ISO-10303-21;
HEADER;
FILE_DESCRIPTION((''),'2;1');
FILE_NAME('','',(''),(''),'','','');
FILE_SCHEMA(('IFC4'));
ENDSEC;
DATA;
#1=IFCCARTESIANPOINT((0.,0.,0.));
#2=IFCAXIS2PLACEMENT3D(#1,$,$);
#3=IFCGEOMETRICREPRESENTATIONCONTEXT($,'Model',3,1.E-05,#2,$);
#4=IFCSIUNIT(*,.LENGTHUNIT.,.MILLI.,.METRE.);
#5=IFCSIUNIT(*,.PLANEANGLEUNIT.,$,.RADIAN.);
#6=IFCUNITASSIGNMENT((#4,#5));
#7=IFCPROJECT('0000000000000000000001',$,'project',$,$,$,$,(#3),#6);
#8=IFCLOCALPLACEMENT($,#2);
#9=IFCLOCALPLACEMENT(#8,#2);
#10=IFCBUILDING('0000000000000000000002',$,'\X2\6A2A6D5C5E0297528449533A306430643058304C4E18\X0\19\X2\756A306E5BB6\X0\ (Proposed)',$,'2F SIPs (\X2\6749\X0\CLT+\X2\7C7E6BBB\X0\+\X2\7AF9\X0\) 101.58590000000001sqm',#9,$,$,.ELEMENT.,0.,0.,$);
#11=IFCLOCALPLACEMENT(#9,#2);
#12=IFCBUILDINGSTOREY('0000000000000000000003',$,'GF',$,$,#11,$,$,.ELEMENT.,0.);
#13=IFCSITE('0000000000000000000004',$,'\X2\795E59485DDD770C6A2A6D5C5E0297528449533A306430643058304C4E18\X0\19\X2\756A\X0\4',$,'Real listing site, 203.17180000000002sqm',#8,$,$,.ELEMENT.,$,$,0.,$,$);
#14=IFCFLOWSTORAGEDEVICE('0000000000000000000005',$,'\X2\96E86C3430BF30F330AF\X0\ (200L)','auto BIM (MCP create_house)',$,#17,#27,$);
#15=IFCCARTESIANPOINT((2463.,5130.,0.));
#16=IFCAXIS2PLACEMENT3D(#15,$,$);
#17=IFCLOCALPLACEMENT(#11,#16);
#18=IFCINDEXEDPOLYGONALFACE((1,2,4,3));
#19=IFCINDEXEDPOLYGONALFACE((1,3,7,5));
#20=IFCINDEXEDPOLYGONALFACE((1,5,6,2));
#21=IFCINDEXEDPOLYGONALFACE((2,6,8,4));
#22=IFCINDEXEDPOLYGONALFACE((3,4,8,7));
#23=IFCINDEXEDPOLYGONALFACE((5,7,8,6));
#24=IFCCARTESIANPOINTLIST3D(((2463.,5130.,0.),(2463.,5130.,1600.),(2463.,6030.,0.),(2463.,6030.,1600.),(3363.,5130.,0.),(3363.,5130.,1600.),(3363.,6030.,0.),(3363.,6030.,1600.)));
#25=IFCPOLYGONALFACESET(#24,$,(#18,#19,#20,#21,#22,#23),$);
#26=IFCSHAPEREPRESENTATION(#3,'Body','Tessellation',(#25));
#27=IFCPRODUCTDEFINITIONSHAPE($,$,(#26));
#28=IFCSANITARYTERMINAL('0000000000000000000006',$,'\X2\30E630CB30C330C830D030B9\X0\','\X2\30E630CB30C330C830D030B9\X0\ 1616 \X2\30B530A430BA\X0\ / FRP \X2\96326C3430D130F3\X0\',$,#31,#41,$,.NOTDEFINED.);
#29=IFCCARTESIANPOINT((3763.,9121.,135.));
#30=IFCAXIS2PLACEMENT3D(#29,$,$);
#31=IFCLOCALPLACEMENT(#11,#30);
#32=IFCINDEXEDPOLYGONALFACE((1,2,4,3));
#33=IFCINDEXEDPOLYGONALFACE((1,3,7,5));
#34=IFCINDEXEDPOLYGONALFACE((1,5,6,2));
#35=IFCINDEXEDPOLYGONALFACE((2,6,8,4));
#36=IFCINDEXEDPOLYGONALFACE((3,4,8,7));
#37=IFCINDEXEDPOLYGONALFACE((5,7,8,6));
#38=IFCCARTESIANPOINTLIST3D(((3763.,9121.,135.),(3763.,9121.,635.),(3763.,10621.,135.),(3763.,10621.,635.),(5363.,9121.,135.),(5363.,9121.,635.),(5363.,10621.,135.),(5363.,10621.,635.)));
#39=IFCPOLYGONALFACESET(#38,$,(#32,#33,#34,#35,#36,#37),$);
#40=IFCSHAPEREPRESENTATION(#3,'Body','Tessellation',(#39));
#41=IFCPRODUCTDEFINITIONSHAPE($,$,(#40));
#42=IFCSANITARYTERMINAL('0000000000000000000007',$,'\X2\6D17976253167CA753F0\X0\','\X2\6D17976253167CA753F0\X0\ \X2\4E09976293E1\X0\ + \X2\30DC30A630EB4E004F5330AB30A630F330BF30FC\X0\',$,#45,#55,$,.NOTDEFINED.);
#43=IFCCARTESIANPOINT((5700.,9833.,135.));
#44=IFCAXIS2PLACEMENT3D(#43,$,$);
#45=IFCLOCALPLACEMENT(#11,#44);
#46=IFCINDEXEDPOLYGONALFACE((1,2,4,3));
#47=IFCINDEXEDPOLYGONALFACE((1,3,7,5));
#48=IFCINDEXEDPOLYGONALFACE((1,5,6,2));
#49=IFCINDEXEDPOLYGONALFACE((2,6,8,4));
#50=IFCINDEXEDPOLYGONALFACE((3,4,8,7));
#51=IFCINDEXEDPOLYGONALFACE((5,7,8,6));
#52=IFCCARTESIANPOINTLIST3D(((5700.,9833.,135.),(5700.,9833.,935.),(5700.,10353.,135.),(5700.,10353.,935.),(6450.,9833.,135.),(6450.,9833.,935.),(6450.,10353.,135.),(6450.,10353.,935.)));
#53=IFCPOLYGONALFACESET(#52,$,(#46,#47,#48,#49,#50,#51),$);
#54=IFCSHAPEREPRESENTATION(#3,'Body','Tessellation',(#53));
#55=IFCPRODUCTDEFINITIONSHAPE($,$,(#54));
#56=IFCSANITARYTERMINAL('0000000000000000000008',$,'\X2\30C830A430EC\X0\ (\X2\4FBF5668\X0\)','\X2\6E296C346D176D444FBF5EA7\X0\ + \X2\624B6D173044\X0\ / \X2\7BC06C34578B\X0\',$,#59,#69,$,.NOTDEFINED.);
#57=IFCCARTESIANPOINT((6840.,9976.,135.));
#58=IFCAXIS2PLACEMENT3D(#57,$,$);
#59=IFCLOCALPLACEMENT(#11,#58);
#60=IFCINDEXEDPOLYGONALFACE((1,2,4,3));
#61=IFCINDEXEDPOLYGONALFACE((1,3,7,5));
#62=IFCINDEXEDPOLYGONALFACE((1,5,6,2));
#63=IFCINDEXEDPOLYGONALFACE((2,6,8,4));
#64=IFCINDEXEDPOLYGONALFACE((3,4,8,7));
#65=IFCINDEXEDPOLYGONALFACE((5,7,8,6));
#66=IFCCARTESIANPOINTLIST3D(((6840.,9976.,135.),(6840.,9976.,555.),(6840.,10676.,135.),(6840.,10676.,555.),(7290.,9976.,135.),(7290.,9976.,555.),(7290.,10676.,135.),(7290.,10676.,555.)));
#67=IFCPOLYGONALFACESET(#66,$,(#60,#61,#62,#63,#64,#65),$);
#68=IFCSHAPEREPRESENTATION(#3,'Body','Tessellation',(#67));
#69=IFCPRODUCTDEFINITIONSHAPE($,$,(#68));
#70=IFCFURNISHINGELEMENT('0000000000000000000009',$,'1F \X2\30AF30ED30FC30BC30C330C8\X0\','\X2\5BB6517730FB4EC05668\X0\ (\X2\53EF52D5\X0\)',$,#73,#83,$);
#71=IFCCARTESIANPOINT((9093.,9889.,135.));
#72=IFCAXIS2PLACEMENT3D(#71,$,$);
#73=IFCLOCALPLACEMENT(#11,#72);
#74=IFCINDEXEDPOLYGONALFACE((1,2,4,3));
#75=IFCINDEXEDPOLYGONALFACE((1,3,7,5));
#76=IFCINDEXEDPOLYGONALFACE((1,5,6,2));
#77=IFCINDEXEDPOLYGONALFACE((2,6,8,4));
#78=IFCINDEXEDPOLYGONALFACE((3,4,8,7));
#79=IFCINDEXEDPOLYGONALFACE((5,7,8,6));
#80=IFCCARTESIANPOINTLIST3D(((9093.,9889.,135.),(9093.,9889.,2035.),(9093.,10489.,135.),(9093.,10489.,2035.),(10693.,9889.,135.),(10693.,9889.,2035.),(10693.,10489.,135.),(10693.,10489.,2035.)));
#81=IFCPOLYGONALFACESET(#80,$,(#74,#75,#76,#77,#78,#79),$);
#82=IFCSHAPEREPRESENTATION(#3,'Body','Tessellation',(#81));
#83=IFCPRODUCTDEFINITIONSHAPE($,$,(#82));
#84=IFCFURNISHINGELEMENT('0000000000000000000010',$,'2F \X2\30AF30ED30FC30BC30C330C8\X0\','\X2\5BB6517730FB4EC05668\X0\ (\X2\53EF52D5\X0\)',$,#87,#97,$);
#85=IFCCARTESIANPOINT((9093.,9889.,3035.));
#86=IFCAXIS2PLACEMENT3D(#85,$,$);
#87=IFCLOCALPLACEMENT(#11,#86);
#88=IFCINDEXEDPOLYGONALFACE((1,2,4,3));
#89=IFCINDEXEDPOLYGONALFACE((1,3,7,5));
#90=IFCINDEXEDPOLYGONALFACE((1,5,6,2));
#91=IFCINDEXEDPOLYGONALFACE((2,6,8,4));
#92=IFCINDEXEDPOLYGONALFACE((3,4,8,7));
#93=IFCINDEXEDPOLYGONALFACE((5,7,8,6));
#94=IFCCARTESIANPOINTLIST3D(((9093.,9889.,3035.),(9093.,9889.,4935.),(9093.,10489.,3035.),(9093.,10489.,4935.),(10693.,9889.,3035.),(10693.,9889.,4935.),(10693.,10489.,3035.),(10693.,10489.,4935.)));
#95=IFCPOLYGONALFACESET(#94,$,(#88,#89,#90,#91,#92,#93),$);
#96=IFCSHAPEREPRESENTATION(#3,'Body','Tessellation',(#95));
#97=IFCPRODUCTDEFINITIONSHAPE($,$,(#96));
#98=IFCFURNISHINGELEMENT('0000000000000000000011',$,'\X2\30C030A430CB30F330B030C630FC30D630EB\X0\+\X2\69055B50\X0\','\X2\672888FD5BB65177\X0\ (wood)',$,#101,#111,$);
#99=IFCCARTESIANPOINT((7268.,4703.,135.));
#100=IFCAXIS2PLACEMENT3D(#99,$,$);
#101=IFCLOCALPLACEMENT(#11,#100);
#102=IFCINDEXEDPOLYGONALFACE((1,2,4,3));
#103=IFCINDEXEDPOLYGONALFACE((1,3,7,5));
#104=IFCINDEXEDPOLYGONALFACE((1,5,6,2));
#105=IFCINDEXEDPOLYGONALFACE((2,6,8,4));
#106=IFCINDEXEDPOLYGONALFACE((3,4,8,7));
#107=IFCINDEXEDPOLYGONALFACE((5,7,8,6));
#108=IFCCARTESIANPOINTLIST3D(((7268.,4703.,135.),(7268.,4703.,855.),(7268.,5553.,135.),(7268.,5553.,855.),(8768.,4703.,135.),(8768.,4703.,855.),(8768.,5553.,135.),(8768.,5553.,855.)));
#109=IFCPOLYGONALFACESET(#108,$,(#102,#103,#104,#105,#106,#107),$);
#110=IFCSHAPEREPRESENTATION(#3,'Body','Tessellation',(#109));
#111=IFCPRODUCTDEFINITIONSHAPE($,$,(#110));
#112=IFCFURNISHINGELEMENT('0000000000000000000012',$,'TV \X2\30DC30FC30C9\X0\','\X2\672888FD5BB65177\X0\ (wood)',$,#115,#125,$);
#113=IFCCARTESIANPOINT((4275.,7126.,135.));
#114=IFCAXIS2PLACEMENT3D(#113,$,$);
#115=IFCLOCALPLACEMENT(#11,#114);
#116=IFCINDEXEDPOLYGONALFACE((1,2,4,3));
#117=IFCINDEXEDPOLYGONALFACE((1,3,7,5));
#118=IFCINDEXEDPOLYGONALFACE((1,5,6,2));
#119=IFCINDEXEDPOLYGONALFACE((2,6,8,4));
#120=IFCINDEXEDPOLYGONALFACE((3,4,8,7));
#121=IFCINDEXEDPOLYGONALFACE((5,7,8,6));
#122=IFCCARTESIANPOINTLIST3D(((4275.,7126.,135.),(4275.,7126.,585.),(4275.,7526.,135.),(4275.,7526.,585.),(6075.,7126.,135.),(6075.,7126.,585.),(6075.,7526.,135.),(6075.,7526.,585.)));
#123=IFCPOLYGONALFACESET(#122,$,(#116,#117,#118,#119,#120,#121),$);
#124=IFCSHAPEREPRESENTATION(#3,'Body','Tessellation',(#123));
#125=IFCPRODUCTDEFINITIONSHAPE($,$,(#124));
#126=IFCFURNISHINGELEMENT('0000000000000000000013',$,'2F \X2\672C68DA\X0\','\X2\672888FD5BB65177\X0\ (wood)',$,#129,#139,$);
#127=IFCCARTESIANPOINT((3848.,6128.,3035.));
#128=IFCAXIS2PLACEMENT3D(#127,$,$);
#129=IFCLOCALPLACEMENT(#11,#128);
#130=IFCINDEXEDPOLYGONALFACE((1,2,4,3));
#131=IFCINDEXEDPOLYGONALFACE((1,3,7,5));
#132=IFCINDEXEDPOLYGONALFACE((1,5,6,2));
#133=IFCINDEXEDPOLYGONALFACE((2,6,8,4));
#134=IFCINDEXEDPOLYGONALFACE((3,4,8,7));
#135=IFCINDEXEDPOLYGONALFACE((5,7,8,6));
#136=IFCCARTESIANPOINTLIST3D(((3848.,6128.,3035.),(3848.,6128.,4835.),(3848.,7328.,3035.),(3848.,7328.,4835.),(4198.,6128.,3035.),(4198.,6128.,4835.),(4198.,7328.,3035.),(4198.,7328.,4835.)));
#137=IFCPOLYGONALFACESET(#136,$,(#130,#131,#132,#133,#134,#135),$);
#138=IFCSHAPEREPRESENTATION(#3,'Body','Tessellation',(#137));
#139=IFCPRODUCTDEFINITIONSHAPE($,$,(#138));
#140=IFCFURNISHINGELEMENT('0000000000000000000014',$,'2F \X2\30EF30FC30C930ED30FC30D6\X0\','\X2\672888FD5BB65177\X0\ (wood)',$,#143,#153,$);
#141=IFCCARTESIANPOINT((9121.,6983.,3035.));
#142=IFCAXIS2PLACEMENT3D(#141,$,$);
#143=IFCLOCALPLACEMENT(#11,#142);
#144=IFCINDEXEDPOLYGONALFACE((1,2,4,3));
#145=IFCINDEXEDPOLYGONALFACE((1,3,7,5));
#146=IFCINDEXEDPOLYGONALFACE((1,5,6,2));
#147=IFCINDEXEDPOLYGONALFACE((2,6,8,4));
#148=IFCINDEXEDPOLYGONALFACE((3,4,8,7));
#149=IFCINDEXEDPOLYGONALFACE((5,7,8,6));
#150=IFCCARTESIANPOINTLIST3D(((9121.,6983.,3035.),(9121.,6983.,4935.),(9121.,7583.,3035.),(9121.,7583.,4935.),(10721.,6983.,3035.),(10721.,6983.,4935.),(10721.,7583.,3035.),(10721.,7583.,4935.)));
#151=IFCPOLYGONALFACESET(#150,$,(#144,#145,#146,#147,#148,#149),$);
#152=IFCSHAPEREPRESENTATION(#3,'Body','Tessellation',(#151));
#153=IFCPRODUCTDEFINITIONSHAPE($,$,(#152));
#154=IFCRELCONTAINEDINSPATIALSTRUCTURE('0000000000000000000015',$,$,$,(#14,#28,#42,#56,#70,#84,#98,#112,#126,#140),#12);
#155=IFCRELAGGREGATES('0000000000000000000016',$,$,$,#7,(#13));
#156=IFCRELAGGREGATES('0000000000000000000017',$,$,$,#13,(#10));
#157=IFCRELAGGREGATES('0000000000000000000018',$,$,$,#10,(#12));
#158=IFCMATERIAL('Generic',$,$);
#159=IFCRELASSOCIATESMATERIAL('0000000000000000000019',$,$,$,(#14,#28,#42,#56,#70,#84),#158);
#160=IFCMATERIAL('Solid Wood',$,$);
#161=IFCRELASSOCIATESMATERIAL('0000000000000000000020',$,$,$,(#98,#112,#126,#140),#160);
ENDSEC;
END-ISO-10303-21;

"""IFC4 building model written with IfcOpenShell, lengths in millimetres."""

from ifc_helpers import new_model, si_unit, frame, frame_2d, origin, place, context, project, spatial, rectangle, extrude, material, element, save


model = new_model("IFC4")

# Units and contexts
model_context = context("Model", 3, precision=1e-05, world=origin())
ifc_project = project(units=[si_unit("LENGTHUNIT", "METRE", prefix="MILLI"), si_unit("PLANEANGLEUNIT", "RADIAN")], contexts=[model_context])

# Site, building, storey
site_placement = place(None, origin())
site = spatial("IfcSite", under=ifc_project, at=site_placement, Name="神奈川県横浜市青葉区つつじが丘19番4", ObjectType="Real listing site, 203.17180000000002sqm", CompositionType="ELEMENT", RefElevation=0.0)
building_placement = place(site_placement, origin())
building = spatial("IfcBuilding", under=site, at=building_placement, Name="横浜市青葉区つつじが丘19番の家 (Proposed)", ObjectType="2F SIPs (杉CLT+籾殻+竹) 101.58590000000001sqm", CompositionType="ELEMENT", ElevationOfRefHeight=0.0, ElevationOfTerrain=0.0)
storey_placement = place(building_placement, origin())
storey = spatial("IfcBuildingStorey", under=building, at=storey_placement, Name="GF", CompositionType="ELEMENT", Elevation=0.0)

# Shared definitions
ifc_material_1 = material(Name="Solid Wood")

# Flow storage device
ifc_material_2 = material(Name="Generic")
flow_storage_device_placement = place(storey_placement, frame((2463.0, 5130.0, 0.0)))
element("IfcFlowStorageDevice", 1, at=flow_storage_device_placement, inside=storey, material=ifc_material_2, Name="雨水タンク (200L)", Description="auto BIM (MCP create_house)", context=model_context, shape_type="SweptSolid", body=[
    extrude(rectangle(XDim=900.0, YDim=900.0, at=frame_2d((450.0, 450.0))), frame((2463.0, 5130.0, 0.0)), (0.0, 0.0, 1.0), 1600.0),
])

# Sanitary terminals
sanitary_terminal_1_placement = place(storey_placement, frame((3763.0, 9121.0, 135.0)))
element("IfcSanitaryTerminal", 2, at=sanitary_terminal_1_placement, inside=storey, material=ifc_material_2, Name="ユニットバス", Description="ユニットバス 1616 サイズ / FRP 防水パン", PredefinedType="NOTDEFINED", context=model_context, shape_type="SweptSolid", body=[
    extrude(rectangle(XDim=1600.0, YDim=1500.0, at=frame_2d((800.0, 750.0))), frame((3763.0, 9121.0, 135.0)), (0.0, 0.0, 1.0), 500.0),
])
sanitary_terminal_2_placement = place(storey_placement, frame((5700.0, 9833.0, 135.0)))
element("IfcSanitaryTerminal", 3, at=sanitary_terminal_2_placement, inside=storey, material=ifc_material_2, Name="洗面化粧台", Description="洗面化粧台 三面鏡 + ボウル一体カウンター", PredefinedType="NOTDEFINED", context=model_context, shape_type="SweptSolid", body=[
    extrude(rectangle(XDim=750.0, YDim=520.0, at=frame_2d((375.0, 260.0))), frame((5700.0, 9833.0, 135.0)), (0.0, 0.0, 1.0), 800.0),
])
sanitary_terminal_3_placement = place(storey_placement, frame((6840.0, 9976.0, 135.0)))
element("IfcSanitaryTerminal", 4, at=sanitary_terminal_3_placement, inside=storey, material=ifc_material_2, Name="トイレ (便器)", Description="温水洗浄便座 + 手洗い / 節水型", PredefinedType="NOTDEFINED", context=model_context, shape_type="SweptSolid", body=[
    extrude(rectangle(XDim=450.0, YDim=700.0, at=frame_2d((225.0, 350.0))), frame((6840.0, 9976.0, 135.0)), (0.0, 0.0, 1.0), 420.0),
])

# Furnishing elements
furnishing_1_placement = place(storey_placement, frame((9093.0, 9889.0, 135.0)))
element("IfcFurnishingElement", 5, at=furnishing_1_placement, inside=storey, material=ifc_material_2, Name="1F クローゼット", Description="家具・什器 (可動)", context=model_context, shape_type="SweptSolid", body=[
    extrude(rectangle(XDim=1600.0, YDim=600.0, at=frame_2d((800.0, 300.0))), frame((9093.0, 9889.0, 135.0)), (0.0, 0.0, 1.0), 1900.0),
])
furnishing_2_placement = place(storey_placement, frame((9093.0, 9889.0, 3035.0)))
element("IfcFurnishingElement", 6, at=furnishing_2_placement, inside=storey, material=ifc_material_2, Name="2F クローゼット", Description="家具・什器 (可動)", context=model_context, shape_type="SweptSolid", body=[
    extrude(rectangle(XDim=1600.0, YDim=600.0, at=frame_2d((800.0, 300.0))), frame((9093.0, 9889.0, 3035.0)), (0.0, 0.0, 1.0), 1900.0),
])
furnishing_3_placement = place(storey_placement, frame((7268.0, 4703.0, 135.0)))
element("IfcFurnishingElement", 7, at=furnishing_3_placement, inside=storey, material=ifc_material_1, Name="ダイニングテーブル+椅子", Description="木製家具 (wood)", context=model_context, shape_type="SweptSolid", body=[
    extrude(rectangle(XDim=1500.0, YDim=850.0, at=frame_2d((750.0, 425.0))), frame((7268.0, 4703.0, 135.0)), (0.0, 0.0, 1.0), 720.0),
])
furnishing_4_placement = place(storey_placement, frame((4275.0, 7126.0, 135.0)))
element("IfcFurnishingElement", 8, at=furnishing_4_placement, inside=storey, material=ifc_material_1, Name="TV ボード", Description="木製家具 (wood)", context=model_context, shape_type="SweptSolid", body=[
    extrude(rectangle(XDim=1800.0, YDim=400.0, at=frame_2d((900.0, 200.0))), frame((4275.0, 7126.0, 135.0)), (0.0, 0.0, 1.0), 450.0),
])
furnishing_5_placement = place(storey_placement, frame((3848.0, 6128.0, 3035.0)))
element("IfcFurnishingElement", 9, at=furnishing_5_placement, inside=storey, material=ifc_material_1, Name="2F 本棚", Description="木製家具 (wood)", context=model_context, shape_type="SweptSolid", body=[
    extrude(rectangle(XDim=350.0, YDim=1200.0, at=frame_2d((175.0, 600.0))), frame((3848.0, 6128.0, 3035.0)), (0.0, 0.0, 1.0), 1800.0),
])
furnishing_6_placement = place(storey_placement, frame((9121.0, 6983.0, 3035.0)))
element("IfcFurnishingElement", 10, at=furnishing_6_placement, inside=storey, material=ifc_material_1, Name="2F ワードローブ", Description="木製家具 (wood)", context=model_context, shape_type="SweptSolid", body=[
    extrude(rectangle(XDim=1600.0, YDim=600.0, at=frame_2d((800.0, 300.0))), frame((9121.0, 6983.0, 3035.0)), (0.0, 0.0, 1.0), 1900.0),
])

save(model, "model.ifc")
